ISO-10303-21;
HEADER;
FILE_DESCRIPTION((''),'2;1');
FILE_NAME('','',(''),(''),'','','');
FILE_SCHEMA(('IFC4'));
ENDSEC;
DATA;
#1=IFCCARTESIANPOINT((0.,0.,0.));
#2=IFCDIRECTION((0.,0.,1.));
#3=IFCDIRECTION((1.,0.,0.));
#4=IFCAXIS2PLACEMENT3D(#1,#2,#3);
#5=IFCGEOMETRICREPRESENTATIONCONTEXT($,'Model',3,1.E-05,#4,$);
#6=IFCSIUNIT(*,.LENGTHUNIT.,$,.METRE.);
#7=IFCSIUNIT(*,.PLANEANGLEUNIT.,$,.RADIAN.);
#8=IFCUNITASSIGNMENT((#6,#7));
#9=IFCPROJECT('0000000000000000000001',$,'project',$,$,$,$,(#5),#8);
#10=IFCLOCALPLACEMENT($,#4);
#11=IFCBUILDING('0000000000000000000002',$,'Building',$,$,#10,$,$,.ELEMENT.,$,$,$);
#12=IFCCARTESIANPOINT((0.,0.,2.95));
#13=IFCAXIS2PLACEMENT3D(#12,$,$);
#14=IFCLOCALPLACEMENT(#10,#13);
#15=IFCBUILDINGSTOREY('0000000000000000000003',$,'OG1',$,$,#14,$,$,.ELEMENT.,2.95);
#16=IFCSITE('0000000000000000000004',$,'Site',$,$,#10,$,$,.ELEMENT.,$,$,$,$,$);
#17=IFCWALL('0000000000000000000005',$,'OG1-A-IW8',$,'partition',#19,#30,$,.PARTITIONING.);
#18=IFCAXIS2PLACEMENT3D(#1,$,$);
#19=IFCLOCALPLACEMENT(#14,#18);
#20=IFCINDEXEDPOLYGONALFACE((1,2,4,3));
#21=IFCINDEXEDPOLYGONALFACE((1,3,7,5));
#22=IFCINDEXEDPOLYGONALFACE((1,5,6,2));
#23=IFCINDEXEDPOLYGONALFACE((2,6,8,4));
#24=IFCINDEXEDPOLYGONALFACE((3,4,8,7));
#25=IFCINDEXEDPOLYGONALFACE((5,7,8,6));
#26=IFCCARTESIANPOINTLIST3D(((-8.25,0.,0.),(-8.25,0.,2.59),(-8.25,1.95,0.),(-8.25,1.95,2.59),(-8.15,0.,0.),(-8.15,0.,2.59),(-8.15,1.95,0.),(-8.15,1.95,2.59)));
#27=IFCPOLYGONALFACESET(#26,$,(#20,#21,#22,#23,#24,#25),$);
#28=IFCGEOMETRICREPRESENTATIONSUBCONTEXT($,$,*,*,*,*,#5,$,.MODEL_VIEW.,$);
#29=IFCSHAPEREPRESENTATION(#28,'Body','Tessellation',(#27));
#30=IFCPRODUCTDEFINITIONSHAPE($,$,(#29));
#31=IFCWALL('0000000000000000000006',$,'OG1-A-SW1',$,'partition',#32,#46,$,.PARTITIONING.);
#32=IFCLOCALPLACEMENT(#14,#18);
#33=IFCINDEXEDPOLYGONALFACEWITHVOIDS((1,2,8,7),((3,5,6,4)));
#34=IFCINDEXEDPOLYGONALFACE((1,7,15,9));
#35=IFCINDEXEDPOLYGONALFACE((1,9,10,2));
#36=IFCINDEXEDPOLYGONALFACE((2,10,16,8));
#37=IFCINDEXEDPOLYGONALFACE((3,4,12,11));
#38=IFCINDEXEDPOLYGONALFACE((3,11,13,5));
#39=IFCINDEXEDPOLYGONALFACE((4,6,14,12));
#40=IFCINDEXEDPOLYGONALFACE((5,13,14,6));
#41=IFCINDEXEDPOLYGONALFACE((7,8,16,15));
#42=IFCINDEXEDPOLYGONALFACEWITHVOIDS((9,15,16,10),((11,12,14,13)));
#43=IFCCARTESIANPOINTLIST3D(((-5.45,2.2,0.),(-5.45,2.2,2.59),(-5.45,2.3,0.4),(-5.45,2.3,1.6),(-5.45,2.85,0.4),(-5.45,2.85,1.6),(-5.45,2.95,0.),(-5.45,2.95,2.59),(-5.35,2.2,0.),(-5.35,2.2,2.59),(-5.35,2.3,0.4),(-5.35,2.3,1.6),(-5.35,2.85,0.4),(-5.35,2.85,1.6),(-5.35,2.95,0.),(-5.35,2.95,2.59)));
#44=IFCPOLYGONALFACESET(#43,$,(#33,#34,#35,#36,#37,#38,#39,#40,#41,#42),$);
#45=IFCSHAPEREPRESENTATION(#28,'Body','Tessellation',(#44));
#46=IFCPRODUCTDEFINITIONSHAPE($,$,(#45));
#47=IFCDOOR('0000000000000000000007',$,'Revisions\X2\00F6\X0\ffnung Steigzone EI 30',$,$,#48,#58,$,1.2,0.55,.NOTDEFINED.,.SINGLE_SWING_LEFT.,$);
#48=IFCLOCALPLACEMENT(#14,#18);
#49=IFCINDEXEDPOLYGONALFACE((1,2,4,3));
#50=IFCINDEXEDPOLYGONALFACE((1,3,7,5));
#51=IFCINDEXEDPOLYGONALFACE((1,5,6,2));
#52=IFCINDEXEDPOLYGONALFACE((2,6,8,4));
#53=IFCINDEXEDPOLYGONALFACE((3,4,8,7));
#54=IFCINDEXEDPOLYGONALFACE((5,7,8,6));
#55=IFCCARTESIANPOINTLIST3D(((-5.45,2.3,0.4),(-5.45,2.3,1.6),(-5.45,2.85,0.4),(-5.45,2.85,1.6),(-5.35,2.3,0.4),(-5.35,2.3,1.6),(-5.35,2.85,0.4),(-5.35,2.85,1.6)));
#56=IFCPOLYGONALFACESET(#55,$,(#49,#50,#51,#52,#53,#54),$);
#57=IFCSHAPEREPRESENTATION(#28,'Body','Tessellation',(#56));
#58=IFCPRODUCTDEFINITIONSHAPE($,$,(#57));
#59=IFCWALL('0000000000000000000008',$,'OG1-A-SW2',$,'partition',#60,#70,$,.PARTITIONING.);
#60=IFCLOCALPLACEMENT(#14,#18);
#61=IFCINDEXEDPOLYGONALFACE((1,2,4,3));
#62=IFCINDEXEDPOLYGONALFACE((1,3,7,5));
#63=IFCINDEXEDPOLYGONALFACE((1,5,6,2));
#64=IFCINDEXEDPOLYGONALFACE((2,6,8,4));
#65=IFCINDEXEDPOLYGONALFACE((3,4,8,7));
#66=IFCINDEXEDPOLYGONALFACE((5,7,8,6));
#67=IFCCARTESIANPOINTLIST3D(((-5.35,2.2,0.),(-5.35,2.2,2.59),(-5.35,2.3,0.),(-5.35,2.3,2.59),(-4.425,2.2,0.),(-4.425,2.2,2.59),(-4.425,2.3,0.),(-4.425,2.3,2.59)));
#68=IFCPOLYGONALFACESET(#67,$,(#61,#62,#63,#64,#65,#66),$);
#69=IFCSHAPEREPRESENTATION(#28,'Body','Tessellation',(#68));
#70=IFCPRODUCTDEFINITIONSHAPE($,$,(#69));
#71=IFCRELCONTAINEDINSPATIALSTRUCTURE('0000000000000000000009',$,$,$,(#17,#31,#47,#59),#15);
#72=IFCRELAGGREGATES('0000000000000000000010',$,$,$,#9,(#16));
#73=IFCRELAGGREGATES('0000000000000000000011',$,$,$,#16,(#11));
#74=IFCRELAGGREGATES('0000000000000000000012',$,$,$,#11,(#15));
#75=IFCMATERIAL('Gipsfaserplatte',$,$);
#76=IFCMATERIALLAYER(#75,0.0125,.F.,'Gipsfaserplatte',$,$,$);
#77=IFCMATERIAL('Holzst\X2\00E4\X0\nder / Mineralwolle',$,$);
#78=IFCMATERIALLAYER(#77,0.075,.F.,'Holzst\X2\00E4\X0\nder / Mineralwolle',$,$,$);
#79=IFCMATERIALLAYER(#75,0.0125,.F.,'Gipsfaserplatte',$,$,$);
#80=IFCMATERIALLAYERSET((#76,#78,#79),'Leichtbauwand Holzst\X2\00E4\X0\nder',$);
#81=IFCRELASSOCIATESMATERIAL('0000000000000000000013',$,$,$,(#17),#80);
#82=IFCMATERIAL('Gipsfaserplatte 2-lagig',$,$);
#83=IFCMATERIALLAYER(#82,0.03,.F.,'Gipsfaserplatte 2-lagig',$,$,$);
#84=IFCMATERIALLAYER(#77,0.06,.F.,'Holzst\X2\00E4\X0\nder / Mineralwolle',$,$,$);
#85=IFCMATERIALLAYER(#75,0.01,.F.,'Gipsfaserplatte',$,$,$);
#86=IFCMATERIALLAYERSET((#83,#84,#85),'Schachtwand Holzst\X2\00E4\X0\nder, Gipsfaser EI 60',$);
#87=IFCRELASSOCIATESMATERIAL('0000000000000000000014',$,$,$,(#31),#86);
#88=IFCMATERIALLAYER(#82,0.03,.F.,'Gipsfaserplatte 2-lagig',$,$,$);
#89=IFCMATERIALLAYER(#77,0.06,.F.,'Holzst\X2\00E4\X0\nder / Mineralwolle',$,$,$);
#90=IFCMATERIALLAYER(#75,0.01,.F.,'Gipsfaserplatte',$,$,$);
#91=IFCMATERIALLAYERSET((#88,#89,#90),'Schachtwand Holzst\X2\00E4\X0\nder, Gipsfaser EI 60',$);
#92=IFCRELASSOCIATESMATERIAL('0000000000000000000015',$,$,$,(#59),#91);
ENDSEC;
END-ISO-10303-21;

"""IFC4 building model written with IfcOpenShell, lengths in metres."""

from ifc_helpers import new_model, si_unit, frame, frame_2d, origin, origin_with_axes, place, context, subcontext, project, spatial, rectangle, extrude, material, layer, layer_set, element, fill, save


model = new_model("IFC4")

# Units and contexts
model_context = context("Model", 3, precision=1e-05, world=origin_with_axes())
sub_context = subcontext(model_context, None, None, "MODEL_VIEW")
ifc_project = project(units=[si_unit("LENGTHUNIT", "METRE"), si_unit("PLANEANGLEUNIT", "RADIAN")], contexts=[model_context])

# Site, building, storey
placement = place(None, origin_with_axes())
site = spatial("IfcSite", under=ifc_project, at=placement, Name="Site", CompositionType="ELEMENT")
building = spatial("IfcBuilding", under=site, at=placement, Name="Building", CompositionType="ELEMENT")
storey_placement = place(placement, frame((0.0, 0.0, 2.95)))
storey = spatial("IfcBuildingStorey", under=building, at=storey_placement, Name="OG1", CompositionType="ELEMENT", Elevation=2.95)

# Shared definitions
ifc_material_1 = material(Name="Gipsfaserplatte")

# Shared definitions
ifc_material_2 = material(Name="Gipsfaserplatte 2-lagig")

# Shared definitions
ifc_material_3 = material(Name="Holzständer / Mineralwolle")

# Wall
ifc_layer_1 = layer(ifc_material_1, 0.0125, ventilated=False, Name="Gipsfaserplatte")
ifc_layer_2 = layer(ifc_material_3, 0.075, ventilated=False, Name="Holzständer / Mineralwolle")
ifc_layer_3 = layer(ifc_material_1, 0.0125, ventilated=False, Name="Gipsfaserplatte")
ifc_layer_set_1 = layer_set([ifc_layer_1, ifc_layer_2, ifc_layer_3], Name="Leichtbauwand Holzständer")
wall_1_placement = place(storey_placement, frame((-8.2, 0.0, 0.0), z_axis=(0.0, 0.0, 1.0), x_axis=(0.0, 1.0, 0.0)))
element("IfcWall", 1, at=wall_1_placement, inside=storey, material=ifc_layer_set_1, Name="OG1-A-IW8", ObjectType="partition", PredefinedType="PARTITIONING", context=sub_context, shape_type="SweptSolid", body=[
    extrude(rectangle(XDim=1.95, YDim=0.1, at=frame_2d((0.975, 0.0))), origin(), (0.0, 0.0, 1.0), 2.59),
])

# Wall, opening, door
ifc_layer_4 = layer(ifc_material_2, 0.03, ventilated=False, Name="Gipsfaserplatte 2-lagig")
ifc_layer_5 = layer(ifc_material_3, 0.06, ventilated=False, Name="Holzständer / Mineralwolle")
ifc_layer_6 = layer(ifc_material_1, 0.01, ventilated=False, Name="Gipsfaserplatte")
ifc_layer_set_2 = layer_set([ifc_layer_4, ifc_layer_5, ifc_layer_6], Name="Schachtwand Holzständer, Gipsfaser EI 60")
wall_2_placement = place(storey_placement, frame((-5.4, 2.2, 0.0), z_axis=(0.0, 0.0, 1.0), x_axis=(0.0, 1.0, 0.0)))
wall_2 = element("IfcWall", 2, at=wall_2_placement, inside=storey, material=ifc_layer_set_2, Name="OG1-A-SW1", ObjectType="partition", PredefinedType="PARTITIONING", context=sub_context, shape_type="SweptSolid", body=[
    extrude(rectangle(XDim=0.75, YDim=0.1, at=frame_2d((0.375, 0.0))), origin(), (0.0, 0.0, 1.0), 2.59),
])
opening_1_placement = place(wall_2_placement, frame((0.375, 0.1, 0.4), z_axis=(0.0, -1.0, 0.0), x_axis=(1.0, 0.0, 0.0)))
opening_1 = element("IfcOpeningElement", 3, at=opening_1_placement, cuts=wall_2, PredefinedType="OPENING", context=sub_context, shape_type="SweptSolid", body=[
    extrude(rectangle(XDim=0.55, YDim=1.2, at=frame_2d((0.0, 0.6))), origin(), (0.0, 0.0, 1.0), 0.2),
])
door_1_placement = place(wall_2_placement, frame((0.375, 0.05, 0.4), z_axis=(0.0, -1.0, 0.0), x_axis=(1.0, 0.0, 0.0)))
door_1 = element("IfcDoor", 4, at=door_1_placement, inside=storey, Name="Revisionsöffnung Steigzone EI 30", OperationType="SINGLE_SWING_LEFT", OverallHeight=1.2, OverallWidth=0.55, PredefinedType="NOTDEFINED", context=sub_context, shape_type="SweptSolid", body=[
    extrude(rectangle(XDim=0.55, YDim=1.2, at=frame_2d((0.0, 0.6))), origin(), (0.0, 0.0, 1.0), 0.1),
])
fill(opening_1, door_1)

# Wall
ifc_layer_7 = layer(ifc_material_2, 0.03, ventilated=False, Name="Gipsfaserplatte 2-lagig")
ifc_layer_8 = layer(ifc_material_3, 0.06, ventilated=False, Name="Holzständer / Mineralwolle")
ifc_layer_9 = layer(ifc_material_1, 0.01, ventilated=False, Name="Gipsfaserplatte")
ifc_layer_set_3 = layer_set([ifc_layer_7, ifc_layer_8, ifc_layer_9], Name="Schachtwand Holzständer, Gipsfaser EI 60")
wall_3_placement = place(storey_placement, frame((-5.35, 2.25, 0.0), z_axis=(0.0, 0.0, 1.0), x_axis=(1.0, 0.0, 0.0)))
element("IfcWall", 5, at=wall_3_placement, inside=storey, material=ifc_layer_set_3, Name="OG1-A-SW2", ObjectType="partition", PredefinedType="PARTITIONING", context=sub_context, shape_type="SweptSolid", body=[
    extrude(rectangle(XDim=0.925, YDim=0.1, at=frame_2d((0.4625, 0.0))), origin(), (0.0, 0.0, 1.0), 2.59),
])

save(model, "model.ifc")
